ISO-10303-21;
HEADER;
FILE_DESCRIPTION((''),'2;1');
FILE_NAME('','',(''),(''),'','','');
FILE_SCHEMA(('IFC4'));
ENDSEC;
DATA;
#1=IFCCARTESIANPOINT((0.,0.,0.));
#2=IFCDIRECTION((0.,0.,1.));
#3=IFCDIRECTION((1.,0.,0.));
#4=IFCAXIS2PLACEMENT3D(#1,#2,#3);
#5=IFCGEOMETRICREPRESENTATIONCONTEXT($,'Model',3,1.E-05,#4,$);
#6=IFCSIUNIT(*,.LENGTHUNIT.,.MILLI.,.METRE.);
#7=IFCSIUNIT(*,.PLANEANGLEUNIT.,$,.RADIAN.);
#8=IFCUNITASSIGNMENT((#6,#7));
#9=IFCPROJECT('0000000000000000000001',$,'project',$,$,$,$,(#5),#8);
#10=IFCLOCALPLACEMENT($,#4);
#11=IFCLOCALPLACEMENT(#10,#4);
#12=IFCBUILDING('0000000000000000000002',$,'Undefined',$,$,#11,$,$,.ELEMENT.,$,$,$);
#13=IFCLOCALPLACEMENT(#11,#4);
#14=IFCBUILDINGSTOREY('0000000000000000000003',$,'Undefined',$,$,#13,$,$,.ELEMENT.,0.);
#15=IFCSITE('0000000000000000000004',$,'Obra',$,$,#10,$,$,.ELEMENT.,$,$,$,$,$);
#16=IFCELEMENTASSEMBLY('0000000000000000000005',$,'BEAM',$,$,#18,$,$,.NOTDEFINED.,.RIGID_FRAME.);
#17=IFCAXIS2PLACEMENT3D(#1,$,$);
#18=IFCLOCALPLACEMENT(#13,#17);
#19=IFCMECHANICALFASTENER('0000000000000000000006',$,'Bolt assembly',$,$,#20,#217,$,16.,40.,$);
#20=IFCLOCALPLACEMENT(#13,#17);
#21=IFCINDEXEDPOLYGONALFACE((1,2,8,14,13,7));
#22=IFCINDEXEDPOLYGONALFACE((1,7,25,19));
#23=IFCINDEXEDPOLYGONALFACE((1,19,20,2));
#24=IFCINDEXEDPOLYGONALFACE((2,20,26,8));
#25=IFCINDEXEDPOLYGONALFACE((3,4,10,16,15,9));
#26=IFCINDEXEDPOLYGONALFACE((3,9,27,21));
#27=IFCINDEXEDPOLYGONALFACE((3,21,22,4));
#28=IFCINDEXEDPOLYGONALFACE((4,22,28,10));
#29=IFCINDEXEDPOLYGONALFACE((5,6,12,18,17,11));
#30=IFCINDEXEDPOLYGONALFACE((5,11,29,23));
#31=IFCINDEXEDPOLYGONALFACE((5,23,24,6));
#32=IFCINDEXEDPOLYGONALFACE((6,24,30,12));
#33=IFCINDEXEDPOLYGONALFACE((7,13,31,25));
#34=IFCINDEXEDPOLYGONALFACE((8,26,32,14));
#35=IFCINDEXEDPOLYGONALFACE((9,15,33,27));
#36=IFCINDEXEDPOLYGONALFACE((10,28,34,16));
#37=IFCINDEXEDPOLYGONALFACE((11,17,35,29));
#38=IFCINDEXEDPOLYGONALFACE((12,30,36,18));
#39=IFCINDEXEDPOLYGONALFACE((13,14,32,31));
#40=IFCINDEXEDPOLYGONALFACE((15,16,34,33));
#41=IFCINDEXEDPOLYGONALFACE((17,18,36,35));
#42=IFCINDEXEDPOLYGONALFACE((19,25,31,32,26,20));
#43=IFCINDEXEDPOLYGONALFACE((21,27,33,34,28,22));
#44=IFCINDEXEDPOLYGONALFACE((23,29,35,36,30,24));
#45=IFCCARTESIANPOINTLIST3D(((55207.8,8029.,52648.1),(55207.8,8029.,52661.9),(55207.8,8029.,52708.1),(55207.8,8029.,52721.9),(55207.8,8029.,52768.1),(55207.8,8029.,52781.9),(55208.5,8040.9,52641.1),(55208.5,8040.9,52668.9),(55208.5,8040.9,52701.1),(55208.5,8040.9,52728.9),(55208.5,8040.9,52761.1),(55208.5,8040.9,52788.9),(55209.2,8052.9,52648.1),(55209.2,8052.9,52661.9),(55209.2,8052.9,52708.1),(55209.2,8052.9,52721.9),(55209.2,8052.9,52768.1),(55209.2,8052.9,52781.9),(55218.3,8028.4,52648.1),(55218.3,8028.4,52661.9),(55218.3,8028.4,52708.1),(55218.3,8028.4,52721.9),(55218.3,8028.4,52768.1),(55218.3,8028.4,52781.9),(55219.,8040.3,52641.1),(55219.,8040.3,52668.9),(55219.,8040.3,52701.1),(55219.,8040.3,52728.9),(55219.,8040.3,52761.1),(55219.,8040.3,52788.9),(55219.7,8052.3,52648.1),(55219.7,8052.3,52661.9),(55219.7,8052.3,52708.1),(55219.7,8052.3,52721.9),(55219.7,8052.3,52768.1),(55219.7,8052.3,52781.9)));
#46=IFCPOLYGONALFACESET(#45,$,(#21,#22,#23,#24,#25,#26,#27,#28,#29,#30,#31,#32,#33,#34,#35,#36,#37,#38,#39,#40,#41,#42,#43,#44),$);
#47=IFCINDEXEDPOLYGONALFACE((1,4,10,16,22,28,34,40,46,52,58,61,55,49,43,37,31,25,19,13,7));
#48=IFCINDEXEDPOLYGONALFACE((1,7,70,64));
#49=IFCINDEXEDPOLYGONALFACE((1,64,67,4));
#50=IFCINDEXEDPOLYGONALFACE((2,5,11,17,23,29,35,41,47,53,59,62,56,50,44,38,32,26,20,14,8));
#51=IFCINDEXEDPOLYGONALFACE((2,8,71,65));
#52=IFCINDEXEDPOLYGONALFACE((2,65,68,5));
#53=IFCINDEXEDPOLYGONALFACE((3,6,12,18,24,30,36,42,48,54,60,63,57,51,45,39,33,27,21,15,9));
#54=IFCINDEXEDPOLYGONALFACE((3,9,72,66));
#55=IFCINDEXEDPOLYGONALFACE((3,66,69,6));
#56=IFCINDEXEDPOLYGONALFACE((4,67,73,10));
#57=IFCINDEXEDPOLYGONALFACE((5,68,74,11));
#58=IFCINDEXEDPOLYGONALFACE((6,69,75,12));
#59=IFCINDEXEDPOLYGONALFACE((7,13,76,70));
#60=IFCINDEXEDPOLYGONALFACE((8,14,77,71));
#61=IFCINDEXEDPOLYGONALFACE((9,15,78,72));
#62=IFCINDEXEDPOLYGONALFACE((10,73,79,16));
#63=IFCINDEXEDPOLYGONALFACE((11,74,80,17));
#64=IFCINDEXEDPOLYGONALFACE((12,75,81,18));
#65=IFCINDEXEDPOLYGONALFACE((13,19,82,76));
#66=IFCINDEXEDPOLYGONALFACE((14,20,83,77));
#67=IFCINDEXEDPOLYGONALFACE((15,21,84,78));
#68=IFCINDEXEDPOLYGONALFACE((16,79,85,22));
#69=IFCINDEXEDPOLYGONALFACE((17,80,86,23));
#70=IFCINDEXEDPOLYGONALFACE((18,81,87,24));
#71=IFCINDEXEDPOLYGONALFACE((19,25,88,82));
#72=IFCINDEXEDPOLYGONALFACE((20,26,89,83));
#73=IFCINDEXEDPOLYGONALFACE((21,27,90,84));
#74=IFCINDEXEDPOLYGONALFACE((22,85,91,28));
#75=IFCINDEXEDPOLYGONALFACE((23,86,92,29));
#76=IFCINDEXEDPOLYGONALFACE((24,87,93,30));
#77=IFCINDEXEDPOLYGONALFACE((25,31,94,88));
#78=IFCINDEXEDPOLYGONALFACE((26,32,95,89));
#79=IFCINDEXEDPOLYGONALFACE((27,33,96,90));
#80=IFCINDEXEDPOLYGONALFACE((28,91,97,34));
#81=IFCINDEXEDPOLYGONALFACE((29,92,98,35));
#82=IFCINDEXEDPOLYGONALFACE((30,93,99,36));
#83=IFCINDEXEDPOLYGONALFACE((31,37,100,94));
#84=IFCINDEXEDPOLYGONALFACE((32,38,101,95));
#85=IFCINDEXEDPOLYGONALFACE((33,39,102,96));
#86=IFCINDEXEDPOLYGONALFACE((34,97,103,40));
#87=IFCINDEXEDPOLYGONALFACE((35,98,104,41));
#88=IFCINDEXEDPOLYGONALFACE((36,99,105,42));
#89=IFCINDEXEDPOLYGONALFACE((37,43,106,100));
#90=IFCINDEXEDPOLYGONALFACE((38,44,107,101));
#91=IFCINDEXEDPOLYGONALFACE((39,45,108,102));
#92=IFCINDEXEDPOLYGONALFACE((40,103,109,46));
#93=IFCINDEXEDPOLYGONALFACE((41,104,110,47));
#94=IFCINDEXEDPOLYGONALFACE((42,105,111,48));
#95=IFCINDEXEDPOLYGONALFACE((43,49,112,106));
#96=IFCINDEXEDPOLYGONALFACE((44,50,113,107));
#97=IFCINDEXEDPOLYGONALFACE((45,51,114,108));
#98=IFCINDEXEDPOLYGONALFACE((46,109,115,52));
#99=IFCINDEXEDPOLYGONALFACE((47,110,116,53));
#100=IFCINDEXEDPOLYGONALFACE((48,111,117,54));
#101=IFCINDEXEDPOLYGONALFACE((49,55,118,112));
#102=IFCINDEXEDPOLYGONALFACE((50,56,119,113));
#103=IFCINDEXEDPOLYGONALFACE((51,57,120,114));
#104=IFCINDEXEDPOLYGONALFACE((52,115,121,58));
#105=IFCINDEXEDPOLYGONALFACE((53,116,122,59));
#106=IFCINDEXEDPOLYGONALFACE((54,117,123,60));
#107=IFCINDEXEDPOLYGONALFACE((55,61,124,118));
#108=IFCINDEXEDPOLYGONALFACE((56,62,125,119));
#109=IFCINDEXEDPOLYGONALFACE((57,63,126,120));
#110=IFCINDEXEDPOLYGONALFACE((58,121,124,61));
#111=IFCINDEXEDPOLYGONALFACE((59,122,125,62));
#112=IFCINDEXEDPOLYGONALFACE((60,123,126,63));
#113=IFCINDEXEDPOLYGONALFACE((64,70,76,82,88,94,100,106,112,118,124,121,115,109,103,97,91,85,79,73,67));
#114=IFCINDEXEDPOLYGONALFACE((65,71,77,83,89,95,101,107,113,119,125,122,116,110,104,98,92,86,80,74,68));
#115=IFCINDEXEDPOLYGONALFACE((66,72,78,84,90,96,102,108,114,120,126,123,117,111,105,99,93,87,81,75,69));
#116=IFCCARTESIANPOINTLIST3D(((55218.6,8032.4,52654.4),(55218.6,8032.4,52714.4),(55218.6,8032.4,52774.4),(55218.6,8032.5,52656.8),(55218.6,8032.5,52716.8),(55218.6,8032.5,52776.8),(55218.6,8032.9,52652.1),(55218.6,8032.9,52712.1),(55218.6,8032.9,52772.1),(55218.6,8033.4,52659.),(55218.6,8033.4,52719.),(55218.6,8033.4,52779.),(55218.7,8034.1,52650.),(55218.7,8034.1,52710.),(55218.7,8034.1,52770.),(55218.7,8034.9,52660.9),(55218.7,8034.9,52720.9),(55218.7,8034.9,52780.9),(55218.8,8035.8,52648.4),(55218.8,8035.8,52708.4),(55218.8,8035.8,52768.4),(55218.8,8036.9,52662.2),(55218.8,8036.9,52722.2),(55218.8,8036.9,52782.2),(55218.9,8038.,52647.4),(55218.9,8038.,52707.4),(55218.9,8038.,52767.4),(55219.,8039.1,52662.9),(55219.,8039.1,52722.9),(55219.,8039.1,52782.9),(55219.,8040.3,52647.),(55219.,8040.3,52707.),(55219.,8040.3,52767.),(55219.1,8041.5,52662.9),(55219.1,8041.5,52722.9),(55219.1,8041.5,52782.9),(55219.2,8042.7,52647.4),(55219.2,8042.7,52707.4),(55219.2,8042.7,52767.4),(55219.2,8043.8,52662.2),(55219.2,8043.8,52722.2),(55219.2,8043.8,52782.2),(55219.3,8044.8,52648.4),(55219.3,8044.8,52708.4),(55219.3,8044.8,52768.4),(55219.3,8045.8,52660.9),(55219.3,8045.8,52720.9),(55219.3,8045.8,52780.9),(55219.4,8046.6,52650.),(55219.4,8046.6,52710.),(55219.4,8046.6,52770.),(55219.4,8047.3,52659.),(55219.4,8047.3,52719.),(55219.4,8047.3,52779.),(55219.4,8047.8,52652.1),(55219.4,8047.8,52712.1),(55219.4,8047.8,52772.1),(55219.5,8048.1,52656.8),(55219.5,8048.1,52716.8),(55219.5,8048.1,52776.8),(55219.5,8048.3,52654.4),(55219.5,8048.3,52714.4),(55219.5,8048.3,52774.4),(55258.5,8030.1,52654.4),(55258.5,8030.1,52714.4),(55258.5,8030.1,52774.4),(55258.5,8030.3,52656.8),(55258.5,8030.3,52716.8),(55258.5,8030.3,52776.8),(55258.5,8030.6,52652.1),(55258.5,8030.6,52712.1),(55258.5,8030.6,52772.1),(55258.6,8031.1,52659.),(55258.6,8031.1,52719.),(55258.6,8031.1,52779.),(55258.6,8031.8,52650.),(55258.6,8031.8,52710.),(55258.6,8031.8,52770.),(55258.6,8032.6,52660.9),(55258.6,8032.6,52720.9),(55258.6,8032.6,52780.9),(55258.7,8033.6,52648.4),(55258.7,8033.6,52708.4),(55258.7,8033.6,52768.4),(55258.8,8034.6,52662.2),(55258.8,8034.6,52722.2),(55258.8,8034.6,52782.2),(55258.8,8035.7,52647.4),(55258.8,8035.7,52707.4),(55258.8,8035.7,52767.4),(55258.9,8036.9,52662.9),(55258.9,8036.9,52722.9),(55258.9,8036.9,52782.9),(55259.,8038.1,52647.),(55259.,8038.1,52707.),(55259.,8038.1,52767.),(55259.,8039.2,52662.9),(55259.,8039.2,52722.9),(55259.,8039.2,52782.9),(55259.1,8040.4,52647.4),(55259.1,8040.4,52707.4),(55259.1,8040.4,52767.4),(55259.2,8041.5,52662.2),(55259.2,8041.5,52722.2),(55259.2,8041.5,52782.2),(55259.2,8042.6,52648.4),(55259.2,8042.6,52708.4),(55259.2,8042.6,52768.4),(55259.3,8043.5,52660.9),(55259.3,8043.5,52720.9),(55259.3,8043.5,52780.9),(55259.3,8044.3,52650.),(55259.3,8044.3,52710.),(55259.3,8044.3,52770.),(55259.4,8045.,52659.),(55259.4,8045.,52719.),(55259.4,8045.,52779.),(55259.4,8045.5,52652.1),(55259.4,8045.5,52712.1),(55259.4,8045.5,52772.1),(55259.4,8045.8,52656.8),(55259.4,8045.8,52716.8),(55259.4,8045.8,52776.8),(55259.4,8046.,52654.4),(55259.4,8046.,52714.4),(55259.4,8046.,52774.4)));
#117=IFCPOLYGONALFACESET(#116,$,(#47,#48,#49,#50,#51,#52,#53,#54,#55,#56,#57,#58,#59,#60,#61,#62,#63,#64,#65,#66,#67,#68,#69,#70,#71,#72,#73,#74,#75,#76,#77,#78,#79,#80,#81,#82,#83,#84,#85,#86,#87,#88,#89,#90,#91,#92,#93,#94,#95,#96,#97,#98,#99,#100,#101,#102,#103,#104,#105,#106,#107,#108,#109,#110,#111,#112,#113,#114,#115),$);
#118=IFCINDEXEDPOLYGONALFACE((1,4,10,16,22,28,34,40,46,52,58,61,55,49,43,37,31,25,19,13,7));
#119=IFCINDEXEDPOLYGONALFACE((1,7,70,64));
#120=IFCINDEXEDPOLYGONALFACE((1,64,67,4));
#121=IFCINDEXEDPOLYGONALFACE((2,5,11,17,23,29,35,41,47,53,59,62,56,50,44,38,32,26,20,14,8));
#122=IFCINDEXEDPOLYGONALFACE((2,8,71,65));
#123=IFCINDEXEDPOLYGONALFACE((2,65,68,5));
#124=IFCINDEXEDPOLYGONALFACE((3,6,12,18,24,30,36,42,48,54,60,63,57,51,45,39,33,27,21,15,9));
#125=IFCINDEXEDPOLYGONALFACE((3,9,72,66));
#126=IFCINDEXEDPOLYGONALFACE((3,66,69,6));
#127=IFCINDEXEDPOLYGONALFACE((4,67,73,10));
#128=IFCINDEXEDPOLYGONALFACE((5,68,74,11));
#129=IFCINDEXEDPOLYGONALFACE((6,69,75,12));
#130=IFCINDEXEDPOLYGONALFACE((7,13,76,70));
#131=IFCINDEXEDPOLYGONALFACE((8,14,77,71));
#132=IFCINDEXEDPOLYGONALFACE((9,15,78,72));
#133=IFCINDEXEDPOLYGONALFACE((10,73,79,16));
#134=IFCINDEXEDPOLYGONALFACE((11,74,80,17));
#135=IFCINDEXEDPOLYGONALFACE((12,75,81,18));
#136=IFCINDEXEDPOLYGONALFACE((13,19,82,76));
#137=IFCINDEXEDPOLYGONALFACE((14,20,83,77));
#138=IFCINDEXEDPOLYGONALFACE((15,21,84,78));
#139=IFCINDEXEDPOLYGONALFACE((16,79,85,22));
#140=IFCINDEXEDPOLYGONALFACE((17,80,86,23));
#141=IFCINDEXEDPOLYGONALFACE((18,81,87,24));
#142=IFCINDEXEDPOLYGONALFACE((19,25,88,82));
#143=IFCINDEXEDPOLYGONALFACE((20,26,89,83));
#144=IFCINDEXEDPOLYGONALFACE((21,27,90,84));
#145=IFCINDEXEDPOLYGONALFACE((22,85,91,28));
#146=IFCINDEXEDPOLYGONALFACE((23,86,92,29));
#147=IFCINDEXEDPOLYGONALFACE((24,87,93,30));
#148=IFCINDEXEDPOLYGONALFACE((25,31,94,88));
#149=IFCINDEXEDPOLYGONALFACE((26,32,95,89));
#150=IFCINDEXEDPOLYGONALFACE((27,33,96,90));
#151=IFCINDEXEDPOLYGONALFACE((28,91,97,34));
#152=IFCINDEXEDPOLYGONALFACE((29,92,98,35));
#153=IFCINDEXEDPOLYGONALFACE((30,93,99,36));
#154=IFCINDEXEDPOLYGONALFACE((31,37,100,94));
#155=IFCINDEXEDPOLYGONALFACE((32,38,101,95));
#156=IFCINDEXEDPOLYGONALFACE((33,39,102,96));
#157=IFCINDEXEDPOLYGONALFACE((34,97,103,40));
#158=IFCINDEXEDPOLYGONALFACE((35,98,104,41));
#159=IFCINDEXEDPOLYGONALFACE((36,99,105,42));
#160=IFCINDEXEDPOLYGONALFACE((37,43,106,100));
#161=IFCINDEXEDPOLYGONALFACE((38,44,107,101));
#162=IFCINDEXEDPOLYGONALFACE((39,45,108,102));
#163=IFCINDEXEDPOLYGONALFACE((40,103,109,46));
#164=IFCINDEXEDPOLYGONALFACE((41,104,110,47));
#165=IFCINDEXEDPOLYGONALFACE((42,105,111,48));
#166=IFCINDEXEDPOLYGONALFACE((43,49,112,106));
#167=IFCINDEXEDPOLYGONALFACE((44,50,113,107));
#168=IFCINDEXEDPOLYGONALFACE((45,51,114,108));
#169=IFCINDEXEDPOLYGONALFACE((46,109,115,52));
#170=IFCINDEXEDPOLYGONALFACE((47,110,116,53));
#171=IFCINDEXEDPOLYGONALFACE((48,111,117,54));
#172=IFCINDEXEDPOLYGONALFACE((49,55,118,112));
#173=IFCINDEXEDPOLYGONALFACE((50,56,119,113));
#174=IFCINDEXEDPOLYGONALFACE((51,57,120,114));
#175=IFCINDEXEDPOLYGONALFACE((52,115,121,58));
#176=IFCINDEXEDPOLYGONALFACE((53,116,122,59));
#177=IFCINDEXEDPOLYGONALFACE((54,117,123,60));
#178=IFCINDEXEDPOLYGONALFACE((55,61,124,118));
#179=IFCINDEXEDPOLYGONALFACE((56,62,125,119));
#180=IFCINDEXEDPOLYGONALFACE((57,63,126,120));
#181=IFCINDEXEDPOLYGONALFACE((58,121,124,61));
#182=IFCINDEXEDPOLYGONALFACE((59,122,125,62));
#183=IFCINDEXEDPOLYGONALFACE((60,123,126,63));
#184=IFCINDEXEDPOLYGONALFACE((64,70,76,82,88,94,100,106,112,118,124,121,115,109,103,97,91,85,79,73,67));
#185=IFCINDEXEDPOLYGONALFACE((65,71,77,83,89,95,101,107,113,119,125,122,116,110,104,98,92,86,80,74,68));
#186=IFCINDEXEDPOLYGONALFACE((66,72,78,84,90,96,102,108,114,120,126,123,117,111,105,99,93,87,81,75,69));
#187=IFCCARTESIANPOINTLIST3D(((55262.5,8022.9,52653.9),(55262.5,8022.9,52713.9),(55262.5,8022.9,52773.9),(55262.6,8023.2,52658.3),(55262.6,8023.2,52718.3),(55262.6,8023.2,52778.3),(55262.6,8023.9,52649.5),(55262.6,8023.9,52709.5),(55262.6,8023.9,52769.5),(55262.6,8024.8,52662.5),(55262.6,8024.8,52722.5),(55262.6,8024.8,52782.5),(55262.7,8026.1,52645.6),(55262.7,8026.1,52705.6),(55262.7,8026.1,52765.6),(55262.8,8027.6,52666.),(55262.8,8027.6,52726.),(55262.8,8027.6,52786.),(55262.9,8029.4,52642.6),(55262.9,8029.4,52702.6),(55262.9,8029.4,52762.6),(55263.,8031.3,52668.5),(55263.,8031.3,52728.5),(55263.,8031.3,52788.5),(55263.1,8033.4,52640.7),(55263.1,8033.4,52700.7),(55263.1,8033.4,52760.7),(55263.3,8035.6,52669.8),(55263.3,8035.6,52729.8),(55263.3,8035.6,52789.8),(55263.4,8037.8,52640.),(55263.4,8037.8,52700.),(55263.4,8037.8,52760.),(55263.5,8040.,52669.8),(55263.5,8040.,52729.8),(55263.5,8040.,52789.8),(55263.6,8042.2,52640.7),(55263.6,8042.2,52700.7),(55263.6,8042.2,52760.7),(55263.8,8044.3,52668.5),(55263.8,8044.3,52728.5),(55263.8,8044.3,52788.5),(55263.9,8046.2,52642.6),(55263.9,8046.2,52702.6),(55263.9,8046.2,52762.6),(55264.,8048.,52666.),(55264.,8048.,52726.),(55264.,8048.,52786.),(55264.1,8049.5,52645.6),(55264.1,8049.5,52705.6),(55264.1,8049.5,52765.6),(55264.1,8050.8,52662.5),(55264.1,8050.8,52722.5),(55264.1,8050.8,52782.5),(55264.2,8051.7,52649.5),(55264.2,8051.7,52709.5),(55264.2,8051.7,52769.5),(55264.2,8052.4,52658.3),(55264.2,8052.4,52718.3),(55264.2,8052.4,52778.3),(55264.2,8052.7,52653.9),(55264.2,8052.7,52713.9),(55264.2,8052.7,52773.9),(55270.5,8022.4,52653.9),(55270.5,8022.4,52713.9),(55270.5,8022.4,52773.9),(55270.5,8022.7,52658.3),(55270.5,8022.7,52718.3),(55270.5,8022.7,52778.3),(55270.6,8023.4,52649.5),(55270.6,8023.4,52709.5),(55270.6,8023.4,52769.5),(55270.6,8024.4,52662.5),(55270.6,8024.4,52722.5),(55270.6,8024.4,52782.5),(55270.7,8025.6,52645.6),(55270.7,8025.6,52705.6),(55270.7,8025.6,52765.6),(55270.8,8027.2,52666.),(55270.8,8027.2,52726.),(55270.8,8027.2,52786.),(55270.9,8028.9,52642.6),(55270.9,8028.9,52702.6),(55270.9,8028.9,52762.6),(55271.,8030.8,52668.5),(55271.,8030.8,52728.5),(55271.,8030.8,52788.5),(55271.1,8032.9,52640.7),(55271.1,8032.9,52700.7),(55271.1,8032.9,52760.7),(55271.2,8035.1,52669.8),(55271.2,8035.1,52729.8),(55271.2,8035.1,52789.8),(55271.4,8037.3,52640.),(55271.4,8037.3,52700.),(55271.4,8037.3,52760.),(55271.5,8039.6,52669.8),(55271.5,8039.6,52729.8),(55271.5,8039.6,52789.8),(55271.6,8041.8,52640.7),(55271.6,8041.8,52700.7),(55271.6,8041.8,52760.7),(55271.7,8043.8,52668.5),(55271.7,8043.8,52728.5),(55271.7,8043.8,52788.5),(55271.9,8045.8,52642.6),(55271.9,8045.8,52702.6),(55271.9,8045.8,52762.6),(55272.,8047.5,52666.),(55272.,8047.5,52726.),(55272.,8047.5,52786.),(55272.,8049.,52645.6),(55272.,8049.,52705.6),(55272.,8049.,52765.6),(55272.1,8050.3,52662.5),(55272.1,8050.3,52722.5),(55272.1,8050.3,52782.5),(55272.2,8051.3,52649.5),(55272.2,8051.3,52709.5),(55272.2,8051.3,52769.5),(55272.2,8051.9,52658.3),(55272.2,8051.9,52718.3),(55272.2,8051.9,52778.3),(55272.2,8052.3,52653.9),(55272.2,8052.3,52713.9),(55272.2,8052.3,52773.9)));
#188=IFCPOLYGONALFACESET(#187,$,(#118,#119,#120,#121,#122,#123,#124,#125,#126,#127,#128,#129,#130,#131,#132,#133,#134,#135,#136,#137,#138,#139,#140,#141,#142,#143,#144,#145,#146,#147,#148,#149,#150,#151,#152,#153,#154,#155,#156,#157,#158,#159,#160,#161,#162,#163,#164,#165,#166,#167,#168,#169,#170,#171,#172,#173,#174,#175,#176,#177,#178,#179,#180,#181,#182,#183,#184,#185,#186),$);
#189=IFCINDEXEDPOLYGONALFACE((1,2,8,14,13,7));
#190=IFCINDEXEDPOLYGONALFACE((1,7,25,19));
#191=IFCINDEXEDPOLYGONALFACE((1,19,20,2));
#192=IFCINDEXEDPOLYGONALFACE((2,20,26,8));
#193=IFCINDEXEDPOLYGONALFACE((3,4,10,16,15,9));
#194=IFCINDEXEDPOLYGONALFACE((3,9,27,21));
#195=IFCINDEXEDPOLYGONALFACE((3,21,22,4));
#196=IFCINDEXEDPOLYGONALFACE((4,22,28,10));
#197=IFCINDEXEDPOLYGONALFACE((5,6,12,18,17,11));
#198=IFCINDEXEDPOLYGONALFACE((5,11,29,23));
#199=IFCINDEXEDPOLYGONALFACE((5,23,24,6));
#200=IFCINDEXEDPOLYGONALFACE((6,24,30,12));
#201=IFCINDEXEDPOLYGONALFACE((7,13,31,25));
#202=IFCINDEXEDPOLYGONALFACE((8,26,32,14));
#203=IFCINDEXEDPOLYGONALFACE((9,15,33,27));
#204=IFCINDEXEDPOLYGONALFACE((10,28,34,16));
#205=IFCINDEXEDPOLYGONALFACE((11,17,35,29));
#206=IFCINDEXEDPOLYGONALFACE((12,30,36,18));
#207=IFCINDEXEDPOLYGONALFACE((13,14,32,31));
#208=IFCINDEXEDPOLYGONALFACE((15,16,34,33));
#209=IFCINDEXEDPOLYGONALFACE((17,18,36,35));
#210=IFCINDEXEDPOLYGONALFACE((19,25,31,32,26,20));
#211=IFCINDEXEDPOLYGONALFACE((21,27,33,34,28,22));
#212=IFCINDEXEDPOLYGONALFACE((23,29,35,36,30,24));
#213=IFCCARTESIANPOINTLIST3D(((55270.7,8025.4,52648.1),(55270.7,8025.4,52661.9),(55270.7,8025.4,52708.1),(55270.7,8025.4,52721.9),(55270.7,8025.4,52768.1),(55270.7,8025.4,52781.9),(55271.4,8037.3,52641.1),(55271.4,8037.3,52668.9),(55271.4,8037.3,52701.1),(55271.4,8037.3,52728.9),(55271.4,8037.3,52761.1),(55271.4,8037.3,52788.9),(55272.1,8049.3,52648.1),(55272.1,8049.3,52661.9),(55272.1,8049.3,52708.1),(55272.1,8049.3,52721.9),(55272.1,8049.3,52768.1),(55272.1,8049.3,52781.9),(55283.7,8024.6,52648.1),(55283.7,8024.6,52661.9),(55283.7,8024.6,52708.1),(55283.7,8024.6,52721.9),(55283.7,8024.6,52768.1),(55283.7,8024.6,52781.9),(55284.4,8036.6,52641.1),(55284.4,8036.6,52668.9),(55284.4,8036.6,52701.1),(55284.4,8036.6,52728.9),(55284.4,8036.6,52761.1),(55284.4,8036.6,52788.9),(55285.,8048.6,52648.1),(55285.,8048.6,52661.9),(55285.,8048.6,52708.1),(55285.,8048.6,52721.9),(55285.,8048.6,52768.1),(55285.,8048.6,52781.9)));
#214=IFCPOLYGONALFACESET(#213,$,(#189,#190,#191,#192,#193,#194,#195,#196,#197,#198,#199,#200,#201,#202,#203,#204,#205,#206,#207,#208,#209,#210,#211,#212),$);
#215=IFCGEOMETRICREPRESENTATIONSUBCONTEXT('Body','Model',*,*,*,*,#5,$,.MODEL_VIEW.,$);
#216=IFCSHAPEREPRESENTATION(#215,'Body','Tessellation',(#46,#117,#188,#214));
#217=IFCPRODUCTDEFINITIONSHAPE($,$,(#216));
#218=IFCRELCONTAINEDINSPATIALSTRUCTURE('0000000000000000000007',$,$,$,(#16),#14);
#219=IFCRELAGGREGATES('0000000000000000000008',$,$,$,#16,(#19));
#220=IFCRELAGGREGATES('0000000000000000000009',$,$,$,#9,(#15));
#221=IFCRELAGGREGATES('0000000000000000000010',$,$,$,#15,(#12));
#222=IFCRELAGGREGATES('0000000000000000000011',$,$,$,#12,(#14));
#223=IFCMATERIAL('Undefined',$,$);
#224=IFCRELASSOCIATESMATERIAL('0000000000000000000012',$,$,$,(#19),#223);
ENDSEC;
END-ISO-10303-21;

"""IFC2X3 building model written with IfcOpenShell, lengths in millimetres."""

from ifc_helpers import new_model, si_unit, frame, origin_with_axes, origin_2d_with_axis, place, context, subcontext, project, spatial, polyline, circle, outline, extrude, source, transform, mapped, material, element, aggregate, save


model = new_model("IFC2X3")

# Units and contexts
model_context = context("Model", 3, precision=1e-05, world=origin_with_axes())
body_context = subcontext(model_context, "Body", "Model", "MODEL_VIEW")
ifc_project = project(units=[si_unit("LENGTHUNIT", "METRE", prefix="MILLI"), si_unit("PLANEANGLEUNIT", "RADIAN")], contexts=[model_context])

# Site, building, storey
site_placement = place(None, origin_with_axes())
site = spatial("IfcSite", under=ifc_project, at=site_placement, Name="Obra", CompositionType="ELEMENT")
building_placement = place(site_placement, origin_with_axes())
building = spatial("IfcBuilding", under=site, at=building_placement, Name="Undefined", CompositionType="ELEMENT")
storey_placement = place(building_placement, origin_with_axes())
storey = spatial("IfcBuildingStorey", under=building, at=storey_placement, Name="Undefined", CompositionType="ELEMENT", Elevation=0.0)

# Element assembly
assembly_1_placement = place(storey_placement, origin_with_axes())
assembly_1 = element("IfcElementAssembly", 1, at=assembly_1_placement, inside=storey, Name="BEAM", AssemblyPlace="NOTDEFINED", PredefinedType="RIGID_FRAME")

# Mechanical fastener
ifc_material_1 = material(Name="Undefined")
shared_shape_1 = source(origin_with_axes(), body_context, "Body", "SweptSolid", [
    extrude(outline(polyline([(13.9, 0.0), (6.9, 12.0), (-6.9, 12.0), (-13.9, 0.0), (-6.9, -12.0), (6.9, -12.0), (13.9, 0.0)])), frame((0.0, -19.7, 0.0), z_axis=(0.0, 1.0, 0.0), x_axis=(1.0, 0.0, 0.0)), (0.0, 0.0, 1.0), 10.6),
    extrude(circle(Radius=8.0, at=origin_2d_with_axis()), frame((0.0, -9.1, 0.0), z_axis=(0.0, 1.0, 0.0), x_axis=(1.0, 0.0, 0.0)), (0.0, 0.0, 1.0), 40.0),
    extrude(circle(Radius=15.0, at=origin_2d_with_axis()), frame((0.0, 35.3, 0.0), z_axis=(0.0, 1.0, 0.0), x_axis=(1.0, 0.0, 0.0)), (0.0, 0.0, 1.0), 8.0),
    extrude(outline(polyline([(13.9, 0.0), (6.9, 12.0), (-6.9, 12.0), (-13.9, 0.0), (-6.9, -12.0), (6.9, -12.0), (13.9, 0.0)])), frame((0.0, 43.3, 0.0), z_axis=(0.0, 1.0, 0.0), x_axis=(1.0, 0.0, 0.0)), (0.0, 0.0, 1.0), 13.0),
])
mechanical_fastener_1_placement = place(assembly_1_placement, frame((55231.0, 8089.7, 52835.0), z_axis=(-0.05711, -0.998368, 0.0), x_axis=(0.0, 0.0, -1.0)))
mechanical_fastener_1 = element("IfcMechanicalFastener", 2, at=mechanical_fastener_1_placement, material=ifc_material_1, Name="Bolt assembly", NominalDiameter=16.0, NominalLength=40.0, context=body_context, shape_type="MappedRepresentation", body=[
    mapped(shared_shape_1, transform((60.0, 0.0, 50.0))),
    mapped(shared_shape_1, transform((120.0, 0.0, 50.0))),
    mapped(shared_shape_1, transform((180.0, 0.0, 50.0))),
])
aggregate(assembly_1, [mechanical_fastener_1])

save(model, "model.ifc")
